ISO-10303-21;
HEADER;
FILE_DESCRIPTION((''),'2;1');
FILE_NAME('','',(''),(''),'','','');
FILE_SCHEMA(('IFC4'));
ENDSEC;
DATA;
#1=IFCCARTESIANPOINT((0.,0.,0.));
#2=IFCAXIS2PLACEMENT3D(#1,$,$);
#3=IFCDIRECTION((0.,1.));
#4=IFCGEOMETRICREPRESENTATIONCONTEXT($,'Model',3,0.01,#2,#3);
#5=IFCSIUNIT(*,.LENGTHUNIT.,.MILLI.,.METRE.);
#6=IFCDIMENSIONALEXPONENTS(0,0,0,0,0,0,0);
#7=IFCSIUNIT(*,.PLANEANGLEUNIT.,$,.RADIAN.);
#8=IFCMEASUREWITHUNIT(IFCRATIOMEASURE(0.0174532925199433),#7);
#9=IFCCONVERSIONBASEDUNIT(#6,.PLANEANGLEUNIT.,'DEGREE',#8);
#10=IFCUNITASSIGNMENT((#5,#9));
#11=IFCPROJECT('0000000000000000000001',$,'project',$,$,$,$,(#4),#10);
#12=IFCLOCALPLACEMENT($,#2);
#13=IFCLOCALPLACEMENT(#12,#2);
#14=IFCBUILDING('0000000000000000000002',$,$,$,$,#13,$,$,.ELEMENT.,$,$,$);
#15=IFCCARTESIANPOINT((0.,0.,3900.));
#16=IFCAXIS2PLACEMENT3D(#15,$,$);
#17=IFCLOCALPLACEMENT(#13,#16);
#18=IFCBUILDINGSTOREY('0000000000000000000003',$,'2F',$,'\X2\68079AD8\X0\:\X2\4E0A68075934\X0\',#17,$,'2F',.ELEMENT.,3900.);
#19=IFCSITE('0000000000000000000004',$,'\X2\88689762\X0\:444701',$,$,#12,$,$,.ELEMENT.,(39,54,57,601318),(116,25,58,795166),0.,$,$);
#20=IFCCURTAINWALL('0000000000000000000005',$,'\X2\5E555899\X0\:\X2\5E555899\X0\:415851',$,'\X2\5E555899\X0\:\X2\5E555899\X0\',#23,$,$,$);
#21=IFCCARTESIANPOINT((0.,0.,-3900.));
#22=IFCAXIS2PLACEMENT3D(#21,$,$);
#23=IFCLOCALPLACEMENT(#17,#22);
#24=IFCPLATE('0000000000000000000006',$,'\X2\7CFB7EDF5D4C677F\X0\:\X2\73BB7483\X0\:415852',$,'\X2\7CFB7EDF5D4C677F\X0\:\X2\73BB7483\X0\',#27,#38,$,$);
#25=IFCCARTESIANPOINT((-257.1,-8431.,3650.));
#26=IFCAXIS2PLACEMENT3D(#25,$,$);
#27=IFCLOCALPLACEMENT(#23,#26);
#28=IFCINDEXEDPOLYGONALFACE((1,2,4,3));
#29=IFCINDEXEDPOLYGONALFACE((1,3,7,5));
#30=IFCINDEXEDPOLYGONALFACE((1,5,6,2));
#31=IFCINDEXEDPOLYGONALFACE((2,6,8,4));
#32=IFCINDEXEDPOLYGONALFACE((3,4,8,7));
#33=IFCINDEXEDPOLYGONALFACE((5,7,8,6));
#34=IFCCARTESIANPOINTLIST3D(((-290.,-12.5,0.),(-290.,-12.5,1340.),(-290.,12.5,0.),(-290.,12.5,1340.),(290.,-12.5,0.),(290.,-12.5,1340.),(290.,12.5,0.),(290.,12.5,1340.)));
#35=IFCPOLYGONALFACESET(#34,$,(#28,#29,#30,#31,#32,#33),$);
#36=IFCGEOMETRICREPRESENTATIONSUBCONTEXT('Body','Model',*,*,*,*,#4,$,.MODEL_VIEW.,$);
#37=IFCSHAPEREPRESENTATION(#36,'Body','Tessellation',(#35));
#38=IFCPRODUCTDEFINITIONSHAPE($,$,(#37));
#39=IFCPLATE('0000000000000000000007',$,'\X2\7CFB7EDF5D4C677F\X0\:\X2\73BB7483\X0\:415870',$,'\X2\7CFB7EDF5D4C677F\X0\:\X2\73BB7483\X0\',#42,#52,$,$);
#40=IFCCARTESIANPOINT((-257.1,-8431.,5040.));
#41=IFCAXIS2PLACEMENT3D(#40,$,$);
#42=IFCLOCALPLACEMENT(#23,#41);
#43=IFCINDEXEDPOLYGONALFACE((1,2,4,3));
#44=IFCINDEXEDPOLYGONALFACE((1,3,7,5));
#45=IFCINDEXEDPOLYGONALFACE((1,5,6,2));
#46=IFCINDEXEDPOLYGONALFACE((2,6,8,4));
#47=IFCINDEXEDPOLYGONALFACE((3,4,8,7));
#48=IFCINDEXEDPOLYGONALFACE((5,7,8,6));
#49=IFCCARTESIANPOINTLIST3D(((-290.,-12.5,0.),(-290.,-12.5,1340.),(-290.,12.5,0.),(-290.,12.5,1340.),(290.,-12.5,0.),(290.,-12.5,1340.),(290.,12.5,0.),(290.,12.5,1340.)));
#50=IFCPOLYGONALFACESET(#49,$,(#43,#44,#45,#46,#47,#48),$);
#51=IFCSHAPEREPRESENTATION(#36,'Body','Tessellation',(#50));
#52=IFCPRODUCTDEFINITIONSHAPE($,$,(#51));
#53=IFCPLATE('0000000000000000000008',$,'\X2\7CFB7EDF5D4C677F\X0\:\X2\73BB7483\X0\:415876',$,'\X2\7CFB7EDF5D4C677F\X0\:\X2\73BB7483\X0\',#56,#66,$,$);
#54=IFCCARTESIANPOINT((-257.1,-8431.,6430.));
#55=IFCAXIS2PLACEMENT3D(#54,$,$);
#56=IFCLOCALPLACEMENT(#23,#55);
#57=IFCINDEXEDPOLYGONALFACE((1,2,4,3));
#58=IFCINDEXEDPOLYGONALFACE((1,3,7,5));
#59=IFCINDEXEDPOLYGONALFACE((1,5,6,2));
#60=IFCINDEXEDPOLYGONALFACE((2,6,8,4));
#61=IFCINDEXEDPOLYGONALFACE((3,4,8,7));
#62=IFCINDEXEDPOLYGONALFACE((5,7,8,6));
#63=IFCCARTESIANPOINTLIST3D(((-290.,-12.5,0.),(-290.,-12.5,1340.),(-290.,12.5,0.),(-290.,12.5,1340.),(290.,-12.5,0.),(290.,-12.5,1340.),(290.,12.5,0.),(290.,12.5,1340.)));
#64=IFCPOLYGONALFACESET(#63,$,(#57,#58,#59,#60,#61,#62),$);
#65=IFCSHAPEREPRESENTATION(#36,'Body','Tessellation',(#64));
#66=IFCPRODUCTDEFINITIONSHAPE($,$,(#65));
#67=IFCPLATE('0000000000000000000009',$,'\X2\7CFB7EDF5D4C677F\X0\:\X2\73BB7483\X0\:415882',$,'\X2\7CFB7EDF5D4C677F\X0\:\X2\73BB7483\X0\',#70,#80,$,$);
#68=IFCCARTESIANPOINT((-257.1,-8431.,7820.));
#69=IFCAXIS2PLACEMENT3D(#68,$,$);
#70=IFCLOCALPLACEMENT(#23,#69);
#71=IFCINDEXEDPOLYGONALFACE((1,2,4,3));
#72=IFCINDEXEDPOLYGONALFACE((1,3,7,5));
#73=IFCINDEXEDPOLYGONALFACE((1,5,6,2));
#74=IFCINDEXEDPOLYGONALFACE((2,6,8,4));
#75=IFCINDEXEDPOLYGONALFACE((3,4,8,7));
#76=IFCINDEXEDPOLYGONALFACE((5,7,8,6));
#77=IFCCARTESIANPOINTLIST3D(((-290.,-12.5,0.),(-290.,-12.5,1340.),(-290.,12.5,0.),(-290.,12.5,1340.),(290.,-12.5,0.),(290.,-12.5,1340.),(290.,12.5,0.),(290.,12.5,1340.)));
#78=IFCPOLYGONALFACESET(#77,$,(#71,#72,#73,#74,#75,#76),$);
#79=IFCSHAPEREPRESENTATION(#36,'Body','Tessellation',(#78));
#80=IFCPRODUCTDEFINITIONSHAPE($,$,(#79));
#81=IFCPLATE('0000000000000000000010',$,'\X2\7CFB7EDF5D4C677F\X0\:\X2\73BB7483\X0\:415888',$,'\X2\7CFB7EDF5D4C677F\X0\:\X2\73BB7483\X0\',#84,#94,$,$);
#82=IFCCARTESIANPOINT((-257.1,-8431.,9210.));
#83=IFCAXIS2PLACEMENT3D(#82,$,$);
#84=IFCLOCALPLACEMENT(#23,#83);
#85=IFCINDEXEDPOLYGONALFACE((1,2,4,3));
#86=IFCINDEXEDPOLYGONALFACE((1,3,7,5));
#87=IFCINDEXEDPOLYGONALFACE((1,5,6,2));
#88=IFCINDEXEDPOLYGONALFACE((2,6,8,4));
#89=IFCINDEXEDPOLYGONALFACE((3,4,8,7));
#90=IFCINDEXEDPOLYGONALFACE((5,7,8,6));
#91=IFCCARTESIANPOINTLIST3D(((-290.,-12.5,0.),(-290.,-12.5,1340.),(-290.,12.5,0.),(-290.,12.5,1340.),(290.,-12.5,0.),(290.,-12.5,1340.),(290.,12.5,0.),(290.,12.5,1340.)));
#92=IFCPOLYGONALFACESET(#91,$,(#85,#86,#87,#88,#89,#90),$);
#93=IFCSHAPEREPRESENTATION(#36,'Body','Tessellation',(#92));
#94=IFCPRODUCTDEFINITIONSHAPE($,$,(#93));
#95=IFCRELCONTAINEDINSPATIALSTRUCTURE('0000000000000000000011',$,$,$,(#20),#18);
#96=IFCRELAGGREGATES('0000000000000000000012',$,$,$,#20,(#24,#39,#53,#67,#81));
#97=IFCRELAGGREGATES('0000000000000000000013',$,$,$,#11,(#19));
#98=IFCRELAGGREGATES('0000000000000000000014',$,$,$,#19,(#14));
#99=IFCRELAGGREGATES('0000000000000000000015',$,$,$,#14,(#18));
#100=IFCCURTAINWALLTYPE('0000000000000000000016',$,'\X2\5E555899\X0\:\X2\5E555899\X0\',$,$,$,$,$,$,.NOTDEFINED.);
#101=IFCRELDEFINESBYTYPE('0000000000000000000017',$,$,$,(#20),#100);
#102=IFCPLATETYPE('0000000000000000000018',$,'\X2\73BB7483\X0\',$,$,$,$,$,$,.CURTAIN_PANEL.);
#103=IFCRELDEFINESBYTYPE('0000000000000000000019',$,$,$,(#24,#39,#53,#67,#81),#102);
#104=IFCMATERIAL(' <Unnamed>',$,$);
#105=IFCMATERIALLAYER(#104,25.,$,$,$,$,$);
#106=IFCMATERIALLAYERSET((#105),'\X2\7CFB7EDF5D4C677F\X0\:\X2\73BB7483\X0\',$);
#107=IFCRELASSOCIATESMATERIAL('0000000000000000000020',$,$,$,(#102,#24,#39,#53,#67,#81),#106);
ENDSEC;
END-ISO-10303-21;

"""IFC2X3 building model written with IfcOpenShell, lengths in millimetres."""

from ifc_helpers import new_model, entity, si_unit, converted_unit, direction, frame, origin, origin_2d_with_axis, place, context, subcontext, project, spatial, rectangle, extrude, source, transform, mapped, material, layer, layer_set, layer_usage, type_object, type_shapes, element, aggregate, save


model = new_model("IFC2X3")

# Units and contexts
model_context = context("Model", 3, precision=0.01, world=origin(), true_north=direction((0.0, 1.0)))
body_context = subcontext(model_context, "Body", "Model", "MODEL_VIEW")
ifc_project = project(units=[si_unit("LENGTHUNIT", "METRE", prefix="MILLI"), converted_unit("PLANEANGLEUNIT", "DEGREE", entity("IfcRatioMeasure", 0.0174532925199433), si_unit("PLANEANGLEUNIT", "RADIAN"), dimensions=[0, 0, 0, 0, 0, 0, 0])], contexts=[model_context])

# Site, building, storey
site_placement = place(None, origin())
site = spatial("IfcSite", under=ifc_project, at=site_placement, Name="表面:444701", CompositionType="ELEMENT", RefLatitude=(39, 54, 57, 601318), RefLongitude=(116, 25, 58, 795166), RefElevation=0.0)
building_placement = place(site_placement, origin())
building = spatial("IfcBuilding", under=site, at=building_placement, CompositionType="ELEMENT")
storey_placement = place(building_placement, frame((0.0, 0.0, 3900.0)))
storey = spatial("IfcBuildingStorey", under=building, at=storey_placement, Name="2F", ObjectType="标高:上标头", LongName="2F", CompositionType="ELEMENT", Elevation=3900.0)

# Curtain wall
curtain_wall_type = type_object("IfcCurtainWallType", Name="幕墙:幕墙", PredefinedType="NOTDEFINED")
curtain_wall_1_placement = place(storey_placement, frame((0.0, 0.0, -3900.0)))
curtain_wall_1 = element("IfcCurtainWall", 1, at=curtain_wall_1_placement, inside=storey, type_object=curtain_wall_type, Name="幕墙:幕墙:415851", ObjectType="幕墙:幕墙")

# Plates
ifc_material_1 = material(Name=" <Unnamed>")
ifc_layer_1 = layer(ifc_material_1, 25.0)
ifc_layer_set_1 = layer_set([ifc_layer_1], Name="系统嵌板:玻璃")
ifc_layer_usage_1 = layer_usage(ifc_layer_set_1, "AXIS3", "POSITIVE", 0.0)
plate_type = type_object("IfcPlateType", Name="玻璃", PredefinedType="CURTAIN_PANEL", material=ifc_layer_set_1)
shared_shape_1 = source(origin(), body_context, "Body", "SweptSolid", [
    extrude(rectangle(XDim=25.0, YDim=580.0, at=origin_2d_with_axis()), frame((0.0, 0.0, 0.0), z_axis=(0.0, 0.0, 1.0), x_axis=(0.0, 1.0, 0.0)), (0.0, 0.0, 1.0), 1340.0),
])
type_shapes(plate_type, [shared_shape_1])
plate_1_placement = place(curtain_wall_1_placement, frame((-257.1, -8431.0, 3650.0)))
plate_1 = element("IfcPlate", 2, at=plate_1_placement, type_object=plate_type, material=ifc_layer_usage_1, Name="系统嵌板:玻璃:415852", ObjectType="系统嵌板:玻璃", context=body_context, shape_type="MappedRepresentation", body=[
    mapped(shared_shape_1, transform((0.0, 0.0, 0.0), scale=1.0)),
])
ifc_layer_usage_2 = layer_usage(ifc_layer_set_1, "AXIS3", "POSITIVE", 0.0)
plate_2_placement = place(curtain_wall_1_placement, frame((-257.1, -8431.0, 5040.0)))
plate_2 = element("IfcPlate", 3, at=plate_2_placement, type_object=plate_type, material=ifc_layer_usage_2, Name="系统嵌板:玻璃:415870", ObjectType="系统嵌板:玻璃", context=body_context, shape_type="MappedRepresentation", body=[
    mapped(shared_shape_1, transform((0.0, 0.0, 0.0), scale=1.0)),
])
ifc_layer_usage_3 = layer_usage(ifc_layer_set_1, "AXIS3", "POSITIVE", 0.0)
plate_3_placement = place(curtain_wall_1_placement, frame((-257.1, -8431.0, 6430.0)))
plate_3 = element("IfcPlate", 4, at=plate_3_placement, type_object=plate_type, material=ifc_layer_usage_3, Name="系统嵌板:玻璃:415876", ObjectType="系统嵌板:玻璃", context=body_context, shape_type="MappedRepresentation", body=[
    mapped(shared_shape_1, transform((0.0, 0.0, 0.0), scale=1.0)),
])
ifc_layer_usage_4 = layer_usage(ifc_layer_set_1, "AXIS3", "POSITIVE", 0.0)
plate_4_placement = place(curtain_wall_1_placement, frame((-257.1, -8431.0, 7820.0)))
plate_4 = element("IfcPlate", 5, at=plate_4_placement, type_object=plate_type, material=ifc_layer_usage_4, Name="系统嵌板:玻璃:415882", ObjectType="系统嵌板:玻璃", context=body_context, shape_type="MappedRepresentation", body=[
    mapped(shared_shape_1, transform((0.0, 0.0, 0.0), scale=1.0)),
])
ifc_layer_usage_5 = layer_usage(ifc_layer_set_1, "AXIS3", "POSITIVE", 0.0)
plate_5_placement = place(curtain_wall_1_placement, frame((-257.1, -8431.0, 9210.0)))
plate_5 = element("IfcPlate", 6, at=plate_5_placement, type_object=plate_type, material=ifc_layer_usage_5, Name="系统嵌板:玻璃:415888", ObjectType="系统嵌板:玻璃", context=body_context, shape_type="MappedRepresentation", body=[
    mapped(shared_shape_1, transform((0.0, 0.0, 0.0), scale=1.0)),
])
aggregate(curtain_wall_1, [plate_1, plate_2, plate_3, plate_4, plate_5])

save(model, "model.ifc")
